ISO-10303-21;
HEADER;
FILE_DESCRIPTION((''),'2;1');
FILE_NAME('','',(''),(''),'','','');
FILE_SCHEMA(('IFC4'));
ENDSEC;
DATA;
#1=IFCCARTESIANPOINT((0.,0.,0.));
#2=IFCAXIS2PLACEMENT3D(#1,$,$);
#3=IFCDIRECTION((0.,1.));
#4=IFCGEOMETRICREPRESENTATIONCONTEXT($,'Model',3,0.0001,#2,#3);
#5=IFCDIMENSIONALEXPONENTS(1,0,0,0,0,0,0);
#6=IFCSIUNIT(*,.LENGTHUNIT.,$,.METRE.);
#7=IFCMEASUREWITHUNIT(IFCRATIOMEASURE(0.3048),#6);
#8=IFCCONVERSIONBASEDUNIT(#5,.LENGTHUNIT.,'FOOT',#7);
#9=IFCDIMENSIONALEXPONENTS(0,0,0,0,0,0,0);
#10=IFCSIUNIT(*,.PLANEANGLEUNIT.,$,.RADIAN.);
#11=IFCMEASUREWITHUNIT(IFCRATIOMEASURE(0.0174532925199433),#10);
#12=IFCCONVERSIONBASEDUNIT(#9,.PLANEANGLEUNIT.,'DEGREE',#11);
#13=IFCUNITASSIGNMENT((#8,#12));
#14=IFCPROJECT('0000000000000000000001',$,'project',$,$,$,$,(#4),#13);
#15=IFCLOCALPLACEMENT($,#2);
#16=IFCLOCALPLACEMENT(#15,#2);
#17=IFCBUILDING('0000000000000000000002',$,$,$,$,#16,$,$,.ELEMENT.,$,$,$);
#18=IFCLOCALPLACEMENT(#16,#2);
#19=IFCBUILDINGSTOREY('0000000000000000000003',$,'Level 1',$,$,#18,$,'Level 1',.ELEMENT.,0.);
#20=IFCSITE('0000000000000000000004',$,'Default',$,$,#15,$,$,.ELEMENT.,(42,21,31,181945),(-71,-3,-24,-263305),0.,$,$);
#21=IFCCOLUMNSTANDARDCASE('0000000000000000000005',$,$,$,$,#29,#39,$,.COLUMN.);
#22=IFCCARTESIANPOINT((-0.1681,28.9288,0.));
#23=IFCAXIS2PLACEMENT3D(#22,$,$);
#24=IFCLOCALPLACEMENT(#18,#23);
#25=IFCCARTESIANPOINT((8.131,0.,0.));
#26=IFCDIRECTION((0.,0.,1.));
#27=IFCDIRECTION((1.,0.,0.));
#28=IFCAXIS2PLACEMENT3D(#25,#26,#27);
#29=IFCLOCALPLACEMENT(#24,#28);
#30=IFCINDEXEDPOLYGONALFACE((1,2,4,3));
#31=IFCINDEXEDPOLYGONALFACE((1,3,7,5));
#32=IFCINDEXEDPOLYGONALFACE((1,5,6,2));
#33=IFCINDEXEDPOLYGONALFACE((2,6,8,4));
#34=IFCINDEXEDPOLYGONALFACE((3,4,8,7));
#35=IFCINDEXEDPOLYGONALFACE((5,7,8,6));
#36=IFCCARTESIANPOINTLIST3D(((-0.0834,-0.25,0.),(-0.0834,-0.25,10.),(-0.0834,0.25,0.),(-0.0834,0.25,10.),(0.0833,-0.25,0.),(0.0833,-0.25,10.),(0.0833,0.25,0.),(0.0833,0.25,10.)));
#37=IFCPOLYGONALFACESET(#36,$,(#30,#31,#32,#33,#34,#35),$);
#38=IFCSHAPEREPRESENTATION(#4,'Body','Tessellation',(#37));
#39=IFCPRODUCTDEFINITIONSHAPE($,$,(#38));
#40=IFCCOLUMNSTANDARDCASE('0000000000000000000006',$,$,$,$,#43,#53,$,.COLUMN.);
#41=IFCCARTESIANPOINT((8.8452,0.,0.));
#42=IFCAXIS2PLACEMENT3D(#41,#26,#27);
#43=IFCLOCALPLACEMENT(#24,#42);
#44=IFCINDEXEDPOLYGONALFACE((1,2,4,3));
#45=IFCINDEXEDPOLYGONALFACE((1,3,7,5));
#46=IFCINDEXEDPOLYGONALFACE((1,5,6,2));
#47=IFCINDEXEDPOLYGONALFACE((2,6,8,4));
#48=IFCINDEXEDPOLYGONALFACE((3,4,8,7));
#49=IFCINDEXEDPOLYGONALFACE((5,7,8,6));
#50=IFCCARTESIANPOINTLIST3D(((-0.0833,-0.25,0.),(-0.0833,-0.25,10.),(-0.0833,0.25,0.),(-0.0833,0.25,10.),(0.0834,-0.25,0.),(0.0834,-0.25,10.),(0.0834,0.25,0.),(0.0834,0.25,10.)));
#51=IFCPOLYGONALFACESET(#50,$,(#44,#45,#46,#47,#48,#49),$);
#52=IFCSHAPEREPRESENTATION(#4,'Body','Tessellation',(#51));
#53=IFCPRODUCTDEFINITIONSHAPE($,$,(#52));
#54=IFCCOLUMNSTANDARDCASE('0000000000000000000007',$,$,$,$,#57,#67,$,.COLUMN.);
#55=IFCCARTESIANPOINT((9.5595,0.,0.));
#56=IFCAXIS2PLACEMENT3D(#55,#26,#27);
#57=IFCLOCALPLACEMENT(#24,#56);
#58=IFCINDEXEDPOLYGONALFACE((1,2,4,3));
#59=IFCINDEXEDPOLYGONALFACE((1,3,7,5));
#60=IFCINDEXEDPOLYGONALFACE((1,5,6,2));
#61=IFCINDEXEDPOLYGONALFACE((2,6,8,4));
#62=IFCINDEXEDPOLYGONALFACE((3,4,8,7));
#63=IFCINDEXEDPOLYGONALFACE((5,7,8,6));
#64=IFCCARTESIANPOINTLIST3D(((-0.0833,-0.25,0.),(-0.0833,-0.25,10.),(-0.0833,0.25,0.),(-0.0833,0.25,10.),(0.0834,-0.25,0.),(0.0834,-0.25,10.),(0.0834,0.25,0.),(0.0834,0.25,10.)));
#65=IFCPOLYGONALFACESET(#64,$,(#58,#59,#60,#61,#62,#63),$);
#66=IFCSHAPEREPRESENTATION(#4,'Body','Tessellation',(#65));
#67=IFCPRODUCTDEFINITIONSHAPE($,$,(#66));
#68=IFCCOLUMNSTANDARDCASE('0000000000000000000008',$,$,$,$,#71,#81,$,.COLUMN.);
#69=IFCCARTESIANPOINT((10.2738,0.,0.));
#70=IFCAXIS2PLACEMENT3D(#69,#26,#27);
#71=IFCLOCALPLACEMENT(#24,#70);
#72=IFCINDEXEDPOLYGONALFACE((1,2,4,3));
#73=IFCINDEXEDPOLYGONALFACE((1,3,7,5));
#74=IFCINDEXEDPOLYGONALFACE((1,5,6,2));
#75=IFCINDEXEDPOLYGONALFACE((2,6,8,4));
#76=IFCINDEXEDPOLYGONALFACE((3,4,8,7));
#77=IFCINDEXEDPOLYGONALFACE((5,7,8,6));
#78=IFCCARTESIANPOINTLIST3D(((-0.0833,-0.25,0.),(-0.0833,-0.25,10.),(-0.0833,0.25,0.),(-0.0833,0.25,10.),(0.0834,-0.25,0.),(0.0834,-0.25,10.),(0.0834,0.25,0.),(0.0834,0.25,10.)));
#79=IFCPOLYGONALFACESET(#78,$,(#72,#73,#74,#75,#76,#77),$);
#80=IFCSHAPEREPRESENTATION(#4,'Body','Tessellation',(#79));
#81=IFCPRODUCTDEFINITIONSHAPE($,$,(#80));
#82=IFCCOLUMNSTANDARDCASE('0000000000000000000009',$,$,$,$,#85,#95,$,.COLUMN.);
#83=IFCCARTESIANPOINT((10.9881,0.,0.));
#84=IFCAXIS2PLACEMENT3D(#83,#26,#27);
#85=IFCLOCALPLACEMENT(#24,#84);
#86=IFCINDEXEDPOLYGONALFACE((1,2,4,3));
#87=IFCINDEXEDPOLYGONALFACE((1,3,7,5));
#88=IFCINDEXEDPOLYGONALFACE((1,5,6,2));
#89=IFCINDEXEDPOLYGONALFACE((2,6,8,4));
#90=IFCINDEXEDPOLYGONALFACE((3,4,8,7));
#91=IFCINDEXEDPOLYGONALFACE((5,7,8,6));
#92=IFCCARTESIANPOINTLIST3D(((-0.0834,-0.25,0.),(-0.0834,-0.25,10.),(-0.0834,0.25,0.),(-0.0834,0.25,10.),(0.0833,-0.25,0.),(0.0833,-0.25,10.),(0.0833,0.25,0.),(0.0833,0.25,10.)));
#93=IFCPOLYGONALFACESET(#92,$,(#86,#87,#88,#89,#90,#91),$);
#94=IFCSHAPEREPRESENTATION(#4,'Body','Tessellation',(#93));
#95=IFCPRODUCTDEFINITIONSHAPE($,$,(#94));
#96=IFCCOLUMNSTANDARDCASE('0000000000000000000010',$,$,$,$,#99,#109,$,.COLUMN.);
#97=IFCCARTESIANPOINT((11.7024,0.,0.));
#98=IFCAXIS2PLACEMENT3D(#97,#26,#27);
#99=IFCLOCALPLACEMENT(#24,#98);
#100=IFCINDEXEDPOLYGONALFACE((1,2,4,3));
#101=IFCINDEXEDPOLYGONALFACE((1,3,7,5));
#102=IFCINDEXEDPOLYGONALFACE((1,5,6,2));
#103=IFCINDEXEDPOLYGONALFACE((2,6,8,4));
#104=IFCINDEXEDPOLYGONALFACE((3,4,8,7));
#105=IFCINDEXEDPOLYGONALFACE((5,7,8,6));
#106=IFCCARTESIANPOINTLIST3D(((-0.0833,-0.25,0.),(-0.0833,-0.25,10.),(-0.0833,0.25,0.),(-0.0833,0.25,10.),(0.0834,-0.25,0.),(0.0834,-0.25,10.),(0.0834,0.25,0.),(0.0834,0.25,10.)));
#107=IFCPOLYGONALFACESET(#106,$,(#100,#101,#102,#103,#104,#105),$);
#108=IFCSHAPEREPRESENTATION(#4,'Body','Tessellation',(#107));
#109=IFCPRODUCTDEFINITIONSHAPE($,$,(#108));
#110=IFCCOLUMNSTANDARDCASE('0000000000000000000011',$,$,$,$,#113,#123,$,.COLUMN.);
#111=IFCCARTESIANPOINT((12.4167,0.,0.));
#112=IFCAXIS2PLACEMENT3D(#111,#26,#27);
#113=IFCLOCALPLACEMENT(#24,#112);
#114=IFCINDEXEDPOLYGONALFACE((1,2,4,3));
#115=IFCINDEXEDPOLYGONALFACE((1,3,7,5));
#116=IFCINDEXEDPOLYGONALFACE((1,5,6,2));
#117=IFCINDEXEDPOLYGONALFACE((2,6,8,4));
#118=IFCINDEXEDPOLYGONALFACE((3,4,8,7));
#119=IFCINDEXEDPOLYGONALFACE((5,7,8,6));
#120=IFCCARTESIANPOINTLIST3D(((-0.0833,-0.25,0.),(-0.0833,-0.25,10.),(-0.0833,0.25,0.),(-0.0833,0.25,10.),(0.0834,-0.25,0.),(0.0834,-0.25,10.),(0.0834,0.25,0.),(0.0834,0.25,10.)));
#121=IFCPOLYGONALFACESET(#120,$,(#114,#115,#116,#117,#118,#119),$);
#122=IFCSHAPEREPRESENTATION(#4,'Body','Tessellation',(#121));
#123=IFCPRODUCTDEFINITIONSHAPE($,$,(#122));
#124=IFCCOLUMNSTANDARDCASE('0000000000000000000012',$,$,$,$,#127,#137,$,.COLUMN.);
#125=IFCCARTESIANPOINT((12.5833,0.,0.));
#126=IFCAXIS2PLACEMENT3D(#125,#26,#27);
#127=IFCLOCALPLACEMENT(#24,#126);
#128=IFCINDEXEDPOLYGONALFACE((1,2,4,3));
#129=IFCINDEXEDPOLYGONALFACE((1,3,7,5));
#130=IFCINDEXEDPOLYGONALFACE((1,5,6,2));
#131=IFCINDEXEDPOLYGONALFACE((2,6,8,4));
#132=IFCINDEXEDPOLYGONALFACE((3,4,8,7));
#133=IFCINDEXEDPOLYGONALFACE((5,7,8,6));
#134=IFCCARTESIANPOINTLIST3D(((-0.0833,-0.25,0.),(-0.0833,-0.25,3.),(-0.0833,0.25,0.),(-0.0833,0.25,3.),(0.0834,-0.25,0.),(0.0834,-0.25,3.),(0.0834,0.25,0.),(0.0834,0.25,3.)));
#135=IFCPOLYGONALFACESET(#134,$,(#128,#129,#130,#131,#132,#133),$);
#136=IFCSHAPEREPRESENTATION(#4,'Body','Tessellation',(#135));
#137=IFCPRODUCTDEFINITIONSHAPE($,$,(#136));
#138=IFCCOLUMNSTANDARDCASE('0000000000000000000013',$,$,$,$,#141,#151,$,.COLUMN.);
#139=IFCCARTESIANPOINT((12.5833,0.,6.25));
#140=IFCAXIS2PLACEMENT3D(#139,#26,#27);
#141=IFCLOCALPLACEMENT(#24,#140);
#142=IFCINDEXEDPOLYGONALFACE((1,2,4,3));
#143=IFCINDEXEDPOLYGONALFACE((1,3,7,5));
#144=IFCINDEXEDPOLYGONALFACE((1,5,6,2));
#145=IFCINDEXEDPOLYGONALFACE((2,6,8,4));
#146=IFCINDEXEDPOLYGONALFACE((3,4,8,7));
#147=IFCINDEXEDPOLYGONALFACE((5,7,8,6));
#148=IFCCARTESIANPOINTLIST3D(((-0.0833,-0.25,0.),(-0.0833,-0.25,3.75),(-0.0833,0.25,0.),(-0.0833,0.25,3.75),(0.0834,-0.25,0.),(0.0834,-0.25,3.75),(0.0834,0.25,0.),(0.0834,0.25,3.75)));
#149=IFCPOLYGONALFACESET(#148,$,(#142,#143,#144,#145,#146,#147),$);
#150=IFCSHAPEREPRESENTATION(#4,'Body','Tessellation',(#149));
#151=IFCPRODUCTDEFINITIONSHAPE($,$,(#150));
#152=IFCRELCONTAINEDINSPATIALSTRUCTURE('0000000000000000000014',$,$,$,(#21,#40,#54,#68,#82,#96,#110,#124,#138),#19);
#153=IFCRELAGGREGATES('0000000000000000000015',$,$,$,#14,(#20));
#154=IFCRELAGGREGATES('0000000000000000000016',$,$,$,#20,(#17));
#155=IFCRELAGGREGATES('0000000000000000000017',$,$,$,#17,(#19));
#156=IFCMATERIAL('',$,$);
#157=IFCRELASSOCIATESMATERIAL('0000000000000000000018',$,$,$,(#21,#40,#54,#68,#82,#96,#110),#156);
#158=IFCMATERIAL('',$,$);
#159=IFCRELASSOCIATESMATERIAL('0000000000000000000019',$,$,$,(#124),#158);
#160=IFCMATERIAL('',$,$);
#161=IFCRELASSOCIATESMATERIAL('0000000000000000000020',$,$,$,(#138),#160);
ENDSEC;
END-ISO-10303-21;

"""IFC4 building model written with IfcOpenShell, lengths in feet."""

from ifc_helpers import new_model, entity, si_unit, converted_unit, direction, frame, origin, place, context, project, spatial, rectangle, extrude, material, element, save


model = new_model("IFC4")

# Units and contexts
model_context = context("Model", 3, precision=0.0001, world=origin(), true_north=direction((0.0, 1.0)))
ifc_project = project(units=[converted_unit("LENGTHUNIT", "FOOT", entity("IfcRatioMeasure", 0.3048), si_unit("LENGTHUNIT", "METRE"), dimensions=[1, 0, 0, 0, 0, 0, 0]), converted_unit("PLANEANGLEUNIT", "DEGREE", entity("IfcRatioMeasure", 0.0174532925199433), si_unit("PLANEANGLEUNIT", "RADIAN"), dimensions=[0, 0, 0, 0, 0, 0, 0])], contexts=[model_context])

# Site, building, storey
site_placement = place(None, origin())
site = spatial("IfcSite", under=ifc_project, at=site_placement, Name="Default", CompositionType="ELEMENT", RefLatitude=(42, 21, 31, 181945), RefLongitude=(-71, -3, -24, -263305), RefElevation=0.0)
building_placement = place(site_placement, origin())
building = spatial("IfcBuilding", under=site, at=building_placement, CompositionType="ELEMENT")
storey_placement = place(building_placement, origin())
storey = spatial("IfcBuildingStorey", under=building, at=storey_placement, Name="Level 1", LongName="Level 1", CompositionType="ELEMENT", Elevation=0.0)

# Columns
ifc_material_1 = material(Name="")
placement = place(storey_placement, frame((-0.1681, 28.9288, 0.0)))
for number, where, z_axis, x_axis in (
    (1, (8.131, 0.0, 0.0), (0.0, 0.0, 1.0), (1.0, 0.0, 0.0)),
    (2, (8.8452, 0.0, 0.0), (0.0, 0.0, 1.0), (1.0, 0.0, 0.0)),
    (3, (9.5595, 0.0, 0.0), (0.0, 0.0, 1.0), (1.0, 0.0, 0.0)),
    (4, (10.2738, 0.0, 0.0), (0.0, 0.0, 1.0), (1.0, 0.0, 0.0)),
    (5, (10.9881, 0.0, 0.0), (0.0, 0.0, 1.0), (1.0, 0.0, 0.0)),
    (6, (11.7024, 0.0, 0.0), (0.0, 0.0, 1.0), (1.0, 0.0, 0.0)),
    (7, (12.4167, 0.0, 0.0), (0.0, 0.0, 1.0), (1.0, 0.0, 0.0)),
):
    element("IfcColumnStandardCase", number, at=place(placement, frame(where, z_axis=z_axis, x_axis=x_axis)), inside=storey, material=ifc_material_1, PredefinedType="COLUMN", context=model_context, shape_type="SweptSolid", body=[
        extrude(rectangle(XDim=0.1667, YDim=0.5), origin(), (0.0, 0.0, 1.0), 10.0),
    ])
ifc_material_2 = material(Name="")
for number, where, z_axis, x_axis in (
    (8, (12.5833, 0.0, 0.0), (0.0, 0.0, 1.0), (1.0, 0.0, 0.0)),
):
    element("IfcColumnStandardCase", number, at=place(placement, frame(where, z_axis=z_axis, x_axis=x_axis)), inside=storey, material=ifc_material_2, PredefinedType="COLUMN", context=model_context, shape_type="SweptSolid", body=[
        extrude(rectangle(XDim=0.1667, YDim=0.5), origin(), (0.0, 0.0, 1.0), 3.0),
    ])
ifc_material_3 = material(Name="")
for number, where, z_axis, x_axis in (
    (9, (12.5833, 0.0, 6.25), (0.0, 0.0, 1.0), (1.0, 0.0, 0.0)),
):
    element("IfcColumnStandardCase", number, at=place(placement, frame(where, z_axis=z_axis, x_axis=x_axis)), inside=storey, material=ifc_material_3, PredefinedType="COLUMN", context=model_context, shape_type="SweptSolid", body=[
        extrude(rectangle(XDim=0.1667, YDim=0.5), origin(), (0.0, 0.0, 1.0), 3.75),
    ])

save(model, "model.ifc")
